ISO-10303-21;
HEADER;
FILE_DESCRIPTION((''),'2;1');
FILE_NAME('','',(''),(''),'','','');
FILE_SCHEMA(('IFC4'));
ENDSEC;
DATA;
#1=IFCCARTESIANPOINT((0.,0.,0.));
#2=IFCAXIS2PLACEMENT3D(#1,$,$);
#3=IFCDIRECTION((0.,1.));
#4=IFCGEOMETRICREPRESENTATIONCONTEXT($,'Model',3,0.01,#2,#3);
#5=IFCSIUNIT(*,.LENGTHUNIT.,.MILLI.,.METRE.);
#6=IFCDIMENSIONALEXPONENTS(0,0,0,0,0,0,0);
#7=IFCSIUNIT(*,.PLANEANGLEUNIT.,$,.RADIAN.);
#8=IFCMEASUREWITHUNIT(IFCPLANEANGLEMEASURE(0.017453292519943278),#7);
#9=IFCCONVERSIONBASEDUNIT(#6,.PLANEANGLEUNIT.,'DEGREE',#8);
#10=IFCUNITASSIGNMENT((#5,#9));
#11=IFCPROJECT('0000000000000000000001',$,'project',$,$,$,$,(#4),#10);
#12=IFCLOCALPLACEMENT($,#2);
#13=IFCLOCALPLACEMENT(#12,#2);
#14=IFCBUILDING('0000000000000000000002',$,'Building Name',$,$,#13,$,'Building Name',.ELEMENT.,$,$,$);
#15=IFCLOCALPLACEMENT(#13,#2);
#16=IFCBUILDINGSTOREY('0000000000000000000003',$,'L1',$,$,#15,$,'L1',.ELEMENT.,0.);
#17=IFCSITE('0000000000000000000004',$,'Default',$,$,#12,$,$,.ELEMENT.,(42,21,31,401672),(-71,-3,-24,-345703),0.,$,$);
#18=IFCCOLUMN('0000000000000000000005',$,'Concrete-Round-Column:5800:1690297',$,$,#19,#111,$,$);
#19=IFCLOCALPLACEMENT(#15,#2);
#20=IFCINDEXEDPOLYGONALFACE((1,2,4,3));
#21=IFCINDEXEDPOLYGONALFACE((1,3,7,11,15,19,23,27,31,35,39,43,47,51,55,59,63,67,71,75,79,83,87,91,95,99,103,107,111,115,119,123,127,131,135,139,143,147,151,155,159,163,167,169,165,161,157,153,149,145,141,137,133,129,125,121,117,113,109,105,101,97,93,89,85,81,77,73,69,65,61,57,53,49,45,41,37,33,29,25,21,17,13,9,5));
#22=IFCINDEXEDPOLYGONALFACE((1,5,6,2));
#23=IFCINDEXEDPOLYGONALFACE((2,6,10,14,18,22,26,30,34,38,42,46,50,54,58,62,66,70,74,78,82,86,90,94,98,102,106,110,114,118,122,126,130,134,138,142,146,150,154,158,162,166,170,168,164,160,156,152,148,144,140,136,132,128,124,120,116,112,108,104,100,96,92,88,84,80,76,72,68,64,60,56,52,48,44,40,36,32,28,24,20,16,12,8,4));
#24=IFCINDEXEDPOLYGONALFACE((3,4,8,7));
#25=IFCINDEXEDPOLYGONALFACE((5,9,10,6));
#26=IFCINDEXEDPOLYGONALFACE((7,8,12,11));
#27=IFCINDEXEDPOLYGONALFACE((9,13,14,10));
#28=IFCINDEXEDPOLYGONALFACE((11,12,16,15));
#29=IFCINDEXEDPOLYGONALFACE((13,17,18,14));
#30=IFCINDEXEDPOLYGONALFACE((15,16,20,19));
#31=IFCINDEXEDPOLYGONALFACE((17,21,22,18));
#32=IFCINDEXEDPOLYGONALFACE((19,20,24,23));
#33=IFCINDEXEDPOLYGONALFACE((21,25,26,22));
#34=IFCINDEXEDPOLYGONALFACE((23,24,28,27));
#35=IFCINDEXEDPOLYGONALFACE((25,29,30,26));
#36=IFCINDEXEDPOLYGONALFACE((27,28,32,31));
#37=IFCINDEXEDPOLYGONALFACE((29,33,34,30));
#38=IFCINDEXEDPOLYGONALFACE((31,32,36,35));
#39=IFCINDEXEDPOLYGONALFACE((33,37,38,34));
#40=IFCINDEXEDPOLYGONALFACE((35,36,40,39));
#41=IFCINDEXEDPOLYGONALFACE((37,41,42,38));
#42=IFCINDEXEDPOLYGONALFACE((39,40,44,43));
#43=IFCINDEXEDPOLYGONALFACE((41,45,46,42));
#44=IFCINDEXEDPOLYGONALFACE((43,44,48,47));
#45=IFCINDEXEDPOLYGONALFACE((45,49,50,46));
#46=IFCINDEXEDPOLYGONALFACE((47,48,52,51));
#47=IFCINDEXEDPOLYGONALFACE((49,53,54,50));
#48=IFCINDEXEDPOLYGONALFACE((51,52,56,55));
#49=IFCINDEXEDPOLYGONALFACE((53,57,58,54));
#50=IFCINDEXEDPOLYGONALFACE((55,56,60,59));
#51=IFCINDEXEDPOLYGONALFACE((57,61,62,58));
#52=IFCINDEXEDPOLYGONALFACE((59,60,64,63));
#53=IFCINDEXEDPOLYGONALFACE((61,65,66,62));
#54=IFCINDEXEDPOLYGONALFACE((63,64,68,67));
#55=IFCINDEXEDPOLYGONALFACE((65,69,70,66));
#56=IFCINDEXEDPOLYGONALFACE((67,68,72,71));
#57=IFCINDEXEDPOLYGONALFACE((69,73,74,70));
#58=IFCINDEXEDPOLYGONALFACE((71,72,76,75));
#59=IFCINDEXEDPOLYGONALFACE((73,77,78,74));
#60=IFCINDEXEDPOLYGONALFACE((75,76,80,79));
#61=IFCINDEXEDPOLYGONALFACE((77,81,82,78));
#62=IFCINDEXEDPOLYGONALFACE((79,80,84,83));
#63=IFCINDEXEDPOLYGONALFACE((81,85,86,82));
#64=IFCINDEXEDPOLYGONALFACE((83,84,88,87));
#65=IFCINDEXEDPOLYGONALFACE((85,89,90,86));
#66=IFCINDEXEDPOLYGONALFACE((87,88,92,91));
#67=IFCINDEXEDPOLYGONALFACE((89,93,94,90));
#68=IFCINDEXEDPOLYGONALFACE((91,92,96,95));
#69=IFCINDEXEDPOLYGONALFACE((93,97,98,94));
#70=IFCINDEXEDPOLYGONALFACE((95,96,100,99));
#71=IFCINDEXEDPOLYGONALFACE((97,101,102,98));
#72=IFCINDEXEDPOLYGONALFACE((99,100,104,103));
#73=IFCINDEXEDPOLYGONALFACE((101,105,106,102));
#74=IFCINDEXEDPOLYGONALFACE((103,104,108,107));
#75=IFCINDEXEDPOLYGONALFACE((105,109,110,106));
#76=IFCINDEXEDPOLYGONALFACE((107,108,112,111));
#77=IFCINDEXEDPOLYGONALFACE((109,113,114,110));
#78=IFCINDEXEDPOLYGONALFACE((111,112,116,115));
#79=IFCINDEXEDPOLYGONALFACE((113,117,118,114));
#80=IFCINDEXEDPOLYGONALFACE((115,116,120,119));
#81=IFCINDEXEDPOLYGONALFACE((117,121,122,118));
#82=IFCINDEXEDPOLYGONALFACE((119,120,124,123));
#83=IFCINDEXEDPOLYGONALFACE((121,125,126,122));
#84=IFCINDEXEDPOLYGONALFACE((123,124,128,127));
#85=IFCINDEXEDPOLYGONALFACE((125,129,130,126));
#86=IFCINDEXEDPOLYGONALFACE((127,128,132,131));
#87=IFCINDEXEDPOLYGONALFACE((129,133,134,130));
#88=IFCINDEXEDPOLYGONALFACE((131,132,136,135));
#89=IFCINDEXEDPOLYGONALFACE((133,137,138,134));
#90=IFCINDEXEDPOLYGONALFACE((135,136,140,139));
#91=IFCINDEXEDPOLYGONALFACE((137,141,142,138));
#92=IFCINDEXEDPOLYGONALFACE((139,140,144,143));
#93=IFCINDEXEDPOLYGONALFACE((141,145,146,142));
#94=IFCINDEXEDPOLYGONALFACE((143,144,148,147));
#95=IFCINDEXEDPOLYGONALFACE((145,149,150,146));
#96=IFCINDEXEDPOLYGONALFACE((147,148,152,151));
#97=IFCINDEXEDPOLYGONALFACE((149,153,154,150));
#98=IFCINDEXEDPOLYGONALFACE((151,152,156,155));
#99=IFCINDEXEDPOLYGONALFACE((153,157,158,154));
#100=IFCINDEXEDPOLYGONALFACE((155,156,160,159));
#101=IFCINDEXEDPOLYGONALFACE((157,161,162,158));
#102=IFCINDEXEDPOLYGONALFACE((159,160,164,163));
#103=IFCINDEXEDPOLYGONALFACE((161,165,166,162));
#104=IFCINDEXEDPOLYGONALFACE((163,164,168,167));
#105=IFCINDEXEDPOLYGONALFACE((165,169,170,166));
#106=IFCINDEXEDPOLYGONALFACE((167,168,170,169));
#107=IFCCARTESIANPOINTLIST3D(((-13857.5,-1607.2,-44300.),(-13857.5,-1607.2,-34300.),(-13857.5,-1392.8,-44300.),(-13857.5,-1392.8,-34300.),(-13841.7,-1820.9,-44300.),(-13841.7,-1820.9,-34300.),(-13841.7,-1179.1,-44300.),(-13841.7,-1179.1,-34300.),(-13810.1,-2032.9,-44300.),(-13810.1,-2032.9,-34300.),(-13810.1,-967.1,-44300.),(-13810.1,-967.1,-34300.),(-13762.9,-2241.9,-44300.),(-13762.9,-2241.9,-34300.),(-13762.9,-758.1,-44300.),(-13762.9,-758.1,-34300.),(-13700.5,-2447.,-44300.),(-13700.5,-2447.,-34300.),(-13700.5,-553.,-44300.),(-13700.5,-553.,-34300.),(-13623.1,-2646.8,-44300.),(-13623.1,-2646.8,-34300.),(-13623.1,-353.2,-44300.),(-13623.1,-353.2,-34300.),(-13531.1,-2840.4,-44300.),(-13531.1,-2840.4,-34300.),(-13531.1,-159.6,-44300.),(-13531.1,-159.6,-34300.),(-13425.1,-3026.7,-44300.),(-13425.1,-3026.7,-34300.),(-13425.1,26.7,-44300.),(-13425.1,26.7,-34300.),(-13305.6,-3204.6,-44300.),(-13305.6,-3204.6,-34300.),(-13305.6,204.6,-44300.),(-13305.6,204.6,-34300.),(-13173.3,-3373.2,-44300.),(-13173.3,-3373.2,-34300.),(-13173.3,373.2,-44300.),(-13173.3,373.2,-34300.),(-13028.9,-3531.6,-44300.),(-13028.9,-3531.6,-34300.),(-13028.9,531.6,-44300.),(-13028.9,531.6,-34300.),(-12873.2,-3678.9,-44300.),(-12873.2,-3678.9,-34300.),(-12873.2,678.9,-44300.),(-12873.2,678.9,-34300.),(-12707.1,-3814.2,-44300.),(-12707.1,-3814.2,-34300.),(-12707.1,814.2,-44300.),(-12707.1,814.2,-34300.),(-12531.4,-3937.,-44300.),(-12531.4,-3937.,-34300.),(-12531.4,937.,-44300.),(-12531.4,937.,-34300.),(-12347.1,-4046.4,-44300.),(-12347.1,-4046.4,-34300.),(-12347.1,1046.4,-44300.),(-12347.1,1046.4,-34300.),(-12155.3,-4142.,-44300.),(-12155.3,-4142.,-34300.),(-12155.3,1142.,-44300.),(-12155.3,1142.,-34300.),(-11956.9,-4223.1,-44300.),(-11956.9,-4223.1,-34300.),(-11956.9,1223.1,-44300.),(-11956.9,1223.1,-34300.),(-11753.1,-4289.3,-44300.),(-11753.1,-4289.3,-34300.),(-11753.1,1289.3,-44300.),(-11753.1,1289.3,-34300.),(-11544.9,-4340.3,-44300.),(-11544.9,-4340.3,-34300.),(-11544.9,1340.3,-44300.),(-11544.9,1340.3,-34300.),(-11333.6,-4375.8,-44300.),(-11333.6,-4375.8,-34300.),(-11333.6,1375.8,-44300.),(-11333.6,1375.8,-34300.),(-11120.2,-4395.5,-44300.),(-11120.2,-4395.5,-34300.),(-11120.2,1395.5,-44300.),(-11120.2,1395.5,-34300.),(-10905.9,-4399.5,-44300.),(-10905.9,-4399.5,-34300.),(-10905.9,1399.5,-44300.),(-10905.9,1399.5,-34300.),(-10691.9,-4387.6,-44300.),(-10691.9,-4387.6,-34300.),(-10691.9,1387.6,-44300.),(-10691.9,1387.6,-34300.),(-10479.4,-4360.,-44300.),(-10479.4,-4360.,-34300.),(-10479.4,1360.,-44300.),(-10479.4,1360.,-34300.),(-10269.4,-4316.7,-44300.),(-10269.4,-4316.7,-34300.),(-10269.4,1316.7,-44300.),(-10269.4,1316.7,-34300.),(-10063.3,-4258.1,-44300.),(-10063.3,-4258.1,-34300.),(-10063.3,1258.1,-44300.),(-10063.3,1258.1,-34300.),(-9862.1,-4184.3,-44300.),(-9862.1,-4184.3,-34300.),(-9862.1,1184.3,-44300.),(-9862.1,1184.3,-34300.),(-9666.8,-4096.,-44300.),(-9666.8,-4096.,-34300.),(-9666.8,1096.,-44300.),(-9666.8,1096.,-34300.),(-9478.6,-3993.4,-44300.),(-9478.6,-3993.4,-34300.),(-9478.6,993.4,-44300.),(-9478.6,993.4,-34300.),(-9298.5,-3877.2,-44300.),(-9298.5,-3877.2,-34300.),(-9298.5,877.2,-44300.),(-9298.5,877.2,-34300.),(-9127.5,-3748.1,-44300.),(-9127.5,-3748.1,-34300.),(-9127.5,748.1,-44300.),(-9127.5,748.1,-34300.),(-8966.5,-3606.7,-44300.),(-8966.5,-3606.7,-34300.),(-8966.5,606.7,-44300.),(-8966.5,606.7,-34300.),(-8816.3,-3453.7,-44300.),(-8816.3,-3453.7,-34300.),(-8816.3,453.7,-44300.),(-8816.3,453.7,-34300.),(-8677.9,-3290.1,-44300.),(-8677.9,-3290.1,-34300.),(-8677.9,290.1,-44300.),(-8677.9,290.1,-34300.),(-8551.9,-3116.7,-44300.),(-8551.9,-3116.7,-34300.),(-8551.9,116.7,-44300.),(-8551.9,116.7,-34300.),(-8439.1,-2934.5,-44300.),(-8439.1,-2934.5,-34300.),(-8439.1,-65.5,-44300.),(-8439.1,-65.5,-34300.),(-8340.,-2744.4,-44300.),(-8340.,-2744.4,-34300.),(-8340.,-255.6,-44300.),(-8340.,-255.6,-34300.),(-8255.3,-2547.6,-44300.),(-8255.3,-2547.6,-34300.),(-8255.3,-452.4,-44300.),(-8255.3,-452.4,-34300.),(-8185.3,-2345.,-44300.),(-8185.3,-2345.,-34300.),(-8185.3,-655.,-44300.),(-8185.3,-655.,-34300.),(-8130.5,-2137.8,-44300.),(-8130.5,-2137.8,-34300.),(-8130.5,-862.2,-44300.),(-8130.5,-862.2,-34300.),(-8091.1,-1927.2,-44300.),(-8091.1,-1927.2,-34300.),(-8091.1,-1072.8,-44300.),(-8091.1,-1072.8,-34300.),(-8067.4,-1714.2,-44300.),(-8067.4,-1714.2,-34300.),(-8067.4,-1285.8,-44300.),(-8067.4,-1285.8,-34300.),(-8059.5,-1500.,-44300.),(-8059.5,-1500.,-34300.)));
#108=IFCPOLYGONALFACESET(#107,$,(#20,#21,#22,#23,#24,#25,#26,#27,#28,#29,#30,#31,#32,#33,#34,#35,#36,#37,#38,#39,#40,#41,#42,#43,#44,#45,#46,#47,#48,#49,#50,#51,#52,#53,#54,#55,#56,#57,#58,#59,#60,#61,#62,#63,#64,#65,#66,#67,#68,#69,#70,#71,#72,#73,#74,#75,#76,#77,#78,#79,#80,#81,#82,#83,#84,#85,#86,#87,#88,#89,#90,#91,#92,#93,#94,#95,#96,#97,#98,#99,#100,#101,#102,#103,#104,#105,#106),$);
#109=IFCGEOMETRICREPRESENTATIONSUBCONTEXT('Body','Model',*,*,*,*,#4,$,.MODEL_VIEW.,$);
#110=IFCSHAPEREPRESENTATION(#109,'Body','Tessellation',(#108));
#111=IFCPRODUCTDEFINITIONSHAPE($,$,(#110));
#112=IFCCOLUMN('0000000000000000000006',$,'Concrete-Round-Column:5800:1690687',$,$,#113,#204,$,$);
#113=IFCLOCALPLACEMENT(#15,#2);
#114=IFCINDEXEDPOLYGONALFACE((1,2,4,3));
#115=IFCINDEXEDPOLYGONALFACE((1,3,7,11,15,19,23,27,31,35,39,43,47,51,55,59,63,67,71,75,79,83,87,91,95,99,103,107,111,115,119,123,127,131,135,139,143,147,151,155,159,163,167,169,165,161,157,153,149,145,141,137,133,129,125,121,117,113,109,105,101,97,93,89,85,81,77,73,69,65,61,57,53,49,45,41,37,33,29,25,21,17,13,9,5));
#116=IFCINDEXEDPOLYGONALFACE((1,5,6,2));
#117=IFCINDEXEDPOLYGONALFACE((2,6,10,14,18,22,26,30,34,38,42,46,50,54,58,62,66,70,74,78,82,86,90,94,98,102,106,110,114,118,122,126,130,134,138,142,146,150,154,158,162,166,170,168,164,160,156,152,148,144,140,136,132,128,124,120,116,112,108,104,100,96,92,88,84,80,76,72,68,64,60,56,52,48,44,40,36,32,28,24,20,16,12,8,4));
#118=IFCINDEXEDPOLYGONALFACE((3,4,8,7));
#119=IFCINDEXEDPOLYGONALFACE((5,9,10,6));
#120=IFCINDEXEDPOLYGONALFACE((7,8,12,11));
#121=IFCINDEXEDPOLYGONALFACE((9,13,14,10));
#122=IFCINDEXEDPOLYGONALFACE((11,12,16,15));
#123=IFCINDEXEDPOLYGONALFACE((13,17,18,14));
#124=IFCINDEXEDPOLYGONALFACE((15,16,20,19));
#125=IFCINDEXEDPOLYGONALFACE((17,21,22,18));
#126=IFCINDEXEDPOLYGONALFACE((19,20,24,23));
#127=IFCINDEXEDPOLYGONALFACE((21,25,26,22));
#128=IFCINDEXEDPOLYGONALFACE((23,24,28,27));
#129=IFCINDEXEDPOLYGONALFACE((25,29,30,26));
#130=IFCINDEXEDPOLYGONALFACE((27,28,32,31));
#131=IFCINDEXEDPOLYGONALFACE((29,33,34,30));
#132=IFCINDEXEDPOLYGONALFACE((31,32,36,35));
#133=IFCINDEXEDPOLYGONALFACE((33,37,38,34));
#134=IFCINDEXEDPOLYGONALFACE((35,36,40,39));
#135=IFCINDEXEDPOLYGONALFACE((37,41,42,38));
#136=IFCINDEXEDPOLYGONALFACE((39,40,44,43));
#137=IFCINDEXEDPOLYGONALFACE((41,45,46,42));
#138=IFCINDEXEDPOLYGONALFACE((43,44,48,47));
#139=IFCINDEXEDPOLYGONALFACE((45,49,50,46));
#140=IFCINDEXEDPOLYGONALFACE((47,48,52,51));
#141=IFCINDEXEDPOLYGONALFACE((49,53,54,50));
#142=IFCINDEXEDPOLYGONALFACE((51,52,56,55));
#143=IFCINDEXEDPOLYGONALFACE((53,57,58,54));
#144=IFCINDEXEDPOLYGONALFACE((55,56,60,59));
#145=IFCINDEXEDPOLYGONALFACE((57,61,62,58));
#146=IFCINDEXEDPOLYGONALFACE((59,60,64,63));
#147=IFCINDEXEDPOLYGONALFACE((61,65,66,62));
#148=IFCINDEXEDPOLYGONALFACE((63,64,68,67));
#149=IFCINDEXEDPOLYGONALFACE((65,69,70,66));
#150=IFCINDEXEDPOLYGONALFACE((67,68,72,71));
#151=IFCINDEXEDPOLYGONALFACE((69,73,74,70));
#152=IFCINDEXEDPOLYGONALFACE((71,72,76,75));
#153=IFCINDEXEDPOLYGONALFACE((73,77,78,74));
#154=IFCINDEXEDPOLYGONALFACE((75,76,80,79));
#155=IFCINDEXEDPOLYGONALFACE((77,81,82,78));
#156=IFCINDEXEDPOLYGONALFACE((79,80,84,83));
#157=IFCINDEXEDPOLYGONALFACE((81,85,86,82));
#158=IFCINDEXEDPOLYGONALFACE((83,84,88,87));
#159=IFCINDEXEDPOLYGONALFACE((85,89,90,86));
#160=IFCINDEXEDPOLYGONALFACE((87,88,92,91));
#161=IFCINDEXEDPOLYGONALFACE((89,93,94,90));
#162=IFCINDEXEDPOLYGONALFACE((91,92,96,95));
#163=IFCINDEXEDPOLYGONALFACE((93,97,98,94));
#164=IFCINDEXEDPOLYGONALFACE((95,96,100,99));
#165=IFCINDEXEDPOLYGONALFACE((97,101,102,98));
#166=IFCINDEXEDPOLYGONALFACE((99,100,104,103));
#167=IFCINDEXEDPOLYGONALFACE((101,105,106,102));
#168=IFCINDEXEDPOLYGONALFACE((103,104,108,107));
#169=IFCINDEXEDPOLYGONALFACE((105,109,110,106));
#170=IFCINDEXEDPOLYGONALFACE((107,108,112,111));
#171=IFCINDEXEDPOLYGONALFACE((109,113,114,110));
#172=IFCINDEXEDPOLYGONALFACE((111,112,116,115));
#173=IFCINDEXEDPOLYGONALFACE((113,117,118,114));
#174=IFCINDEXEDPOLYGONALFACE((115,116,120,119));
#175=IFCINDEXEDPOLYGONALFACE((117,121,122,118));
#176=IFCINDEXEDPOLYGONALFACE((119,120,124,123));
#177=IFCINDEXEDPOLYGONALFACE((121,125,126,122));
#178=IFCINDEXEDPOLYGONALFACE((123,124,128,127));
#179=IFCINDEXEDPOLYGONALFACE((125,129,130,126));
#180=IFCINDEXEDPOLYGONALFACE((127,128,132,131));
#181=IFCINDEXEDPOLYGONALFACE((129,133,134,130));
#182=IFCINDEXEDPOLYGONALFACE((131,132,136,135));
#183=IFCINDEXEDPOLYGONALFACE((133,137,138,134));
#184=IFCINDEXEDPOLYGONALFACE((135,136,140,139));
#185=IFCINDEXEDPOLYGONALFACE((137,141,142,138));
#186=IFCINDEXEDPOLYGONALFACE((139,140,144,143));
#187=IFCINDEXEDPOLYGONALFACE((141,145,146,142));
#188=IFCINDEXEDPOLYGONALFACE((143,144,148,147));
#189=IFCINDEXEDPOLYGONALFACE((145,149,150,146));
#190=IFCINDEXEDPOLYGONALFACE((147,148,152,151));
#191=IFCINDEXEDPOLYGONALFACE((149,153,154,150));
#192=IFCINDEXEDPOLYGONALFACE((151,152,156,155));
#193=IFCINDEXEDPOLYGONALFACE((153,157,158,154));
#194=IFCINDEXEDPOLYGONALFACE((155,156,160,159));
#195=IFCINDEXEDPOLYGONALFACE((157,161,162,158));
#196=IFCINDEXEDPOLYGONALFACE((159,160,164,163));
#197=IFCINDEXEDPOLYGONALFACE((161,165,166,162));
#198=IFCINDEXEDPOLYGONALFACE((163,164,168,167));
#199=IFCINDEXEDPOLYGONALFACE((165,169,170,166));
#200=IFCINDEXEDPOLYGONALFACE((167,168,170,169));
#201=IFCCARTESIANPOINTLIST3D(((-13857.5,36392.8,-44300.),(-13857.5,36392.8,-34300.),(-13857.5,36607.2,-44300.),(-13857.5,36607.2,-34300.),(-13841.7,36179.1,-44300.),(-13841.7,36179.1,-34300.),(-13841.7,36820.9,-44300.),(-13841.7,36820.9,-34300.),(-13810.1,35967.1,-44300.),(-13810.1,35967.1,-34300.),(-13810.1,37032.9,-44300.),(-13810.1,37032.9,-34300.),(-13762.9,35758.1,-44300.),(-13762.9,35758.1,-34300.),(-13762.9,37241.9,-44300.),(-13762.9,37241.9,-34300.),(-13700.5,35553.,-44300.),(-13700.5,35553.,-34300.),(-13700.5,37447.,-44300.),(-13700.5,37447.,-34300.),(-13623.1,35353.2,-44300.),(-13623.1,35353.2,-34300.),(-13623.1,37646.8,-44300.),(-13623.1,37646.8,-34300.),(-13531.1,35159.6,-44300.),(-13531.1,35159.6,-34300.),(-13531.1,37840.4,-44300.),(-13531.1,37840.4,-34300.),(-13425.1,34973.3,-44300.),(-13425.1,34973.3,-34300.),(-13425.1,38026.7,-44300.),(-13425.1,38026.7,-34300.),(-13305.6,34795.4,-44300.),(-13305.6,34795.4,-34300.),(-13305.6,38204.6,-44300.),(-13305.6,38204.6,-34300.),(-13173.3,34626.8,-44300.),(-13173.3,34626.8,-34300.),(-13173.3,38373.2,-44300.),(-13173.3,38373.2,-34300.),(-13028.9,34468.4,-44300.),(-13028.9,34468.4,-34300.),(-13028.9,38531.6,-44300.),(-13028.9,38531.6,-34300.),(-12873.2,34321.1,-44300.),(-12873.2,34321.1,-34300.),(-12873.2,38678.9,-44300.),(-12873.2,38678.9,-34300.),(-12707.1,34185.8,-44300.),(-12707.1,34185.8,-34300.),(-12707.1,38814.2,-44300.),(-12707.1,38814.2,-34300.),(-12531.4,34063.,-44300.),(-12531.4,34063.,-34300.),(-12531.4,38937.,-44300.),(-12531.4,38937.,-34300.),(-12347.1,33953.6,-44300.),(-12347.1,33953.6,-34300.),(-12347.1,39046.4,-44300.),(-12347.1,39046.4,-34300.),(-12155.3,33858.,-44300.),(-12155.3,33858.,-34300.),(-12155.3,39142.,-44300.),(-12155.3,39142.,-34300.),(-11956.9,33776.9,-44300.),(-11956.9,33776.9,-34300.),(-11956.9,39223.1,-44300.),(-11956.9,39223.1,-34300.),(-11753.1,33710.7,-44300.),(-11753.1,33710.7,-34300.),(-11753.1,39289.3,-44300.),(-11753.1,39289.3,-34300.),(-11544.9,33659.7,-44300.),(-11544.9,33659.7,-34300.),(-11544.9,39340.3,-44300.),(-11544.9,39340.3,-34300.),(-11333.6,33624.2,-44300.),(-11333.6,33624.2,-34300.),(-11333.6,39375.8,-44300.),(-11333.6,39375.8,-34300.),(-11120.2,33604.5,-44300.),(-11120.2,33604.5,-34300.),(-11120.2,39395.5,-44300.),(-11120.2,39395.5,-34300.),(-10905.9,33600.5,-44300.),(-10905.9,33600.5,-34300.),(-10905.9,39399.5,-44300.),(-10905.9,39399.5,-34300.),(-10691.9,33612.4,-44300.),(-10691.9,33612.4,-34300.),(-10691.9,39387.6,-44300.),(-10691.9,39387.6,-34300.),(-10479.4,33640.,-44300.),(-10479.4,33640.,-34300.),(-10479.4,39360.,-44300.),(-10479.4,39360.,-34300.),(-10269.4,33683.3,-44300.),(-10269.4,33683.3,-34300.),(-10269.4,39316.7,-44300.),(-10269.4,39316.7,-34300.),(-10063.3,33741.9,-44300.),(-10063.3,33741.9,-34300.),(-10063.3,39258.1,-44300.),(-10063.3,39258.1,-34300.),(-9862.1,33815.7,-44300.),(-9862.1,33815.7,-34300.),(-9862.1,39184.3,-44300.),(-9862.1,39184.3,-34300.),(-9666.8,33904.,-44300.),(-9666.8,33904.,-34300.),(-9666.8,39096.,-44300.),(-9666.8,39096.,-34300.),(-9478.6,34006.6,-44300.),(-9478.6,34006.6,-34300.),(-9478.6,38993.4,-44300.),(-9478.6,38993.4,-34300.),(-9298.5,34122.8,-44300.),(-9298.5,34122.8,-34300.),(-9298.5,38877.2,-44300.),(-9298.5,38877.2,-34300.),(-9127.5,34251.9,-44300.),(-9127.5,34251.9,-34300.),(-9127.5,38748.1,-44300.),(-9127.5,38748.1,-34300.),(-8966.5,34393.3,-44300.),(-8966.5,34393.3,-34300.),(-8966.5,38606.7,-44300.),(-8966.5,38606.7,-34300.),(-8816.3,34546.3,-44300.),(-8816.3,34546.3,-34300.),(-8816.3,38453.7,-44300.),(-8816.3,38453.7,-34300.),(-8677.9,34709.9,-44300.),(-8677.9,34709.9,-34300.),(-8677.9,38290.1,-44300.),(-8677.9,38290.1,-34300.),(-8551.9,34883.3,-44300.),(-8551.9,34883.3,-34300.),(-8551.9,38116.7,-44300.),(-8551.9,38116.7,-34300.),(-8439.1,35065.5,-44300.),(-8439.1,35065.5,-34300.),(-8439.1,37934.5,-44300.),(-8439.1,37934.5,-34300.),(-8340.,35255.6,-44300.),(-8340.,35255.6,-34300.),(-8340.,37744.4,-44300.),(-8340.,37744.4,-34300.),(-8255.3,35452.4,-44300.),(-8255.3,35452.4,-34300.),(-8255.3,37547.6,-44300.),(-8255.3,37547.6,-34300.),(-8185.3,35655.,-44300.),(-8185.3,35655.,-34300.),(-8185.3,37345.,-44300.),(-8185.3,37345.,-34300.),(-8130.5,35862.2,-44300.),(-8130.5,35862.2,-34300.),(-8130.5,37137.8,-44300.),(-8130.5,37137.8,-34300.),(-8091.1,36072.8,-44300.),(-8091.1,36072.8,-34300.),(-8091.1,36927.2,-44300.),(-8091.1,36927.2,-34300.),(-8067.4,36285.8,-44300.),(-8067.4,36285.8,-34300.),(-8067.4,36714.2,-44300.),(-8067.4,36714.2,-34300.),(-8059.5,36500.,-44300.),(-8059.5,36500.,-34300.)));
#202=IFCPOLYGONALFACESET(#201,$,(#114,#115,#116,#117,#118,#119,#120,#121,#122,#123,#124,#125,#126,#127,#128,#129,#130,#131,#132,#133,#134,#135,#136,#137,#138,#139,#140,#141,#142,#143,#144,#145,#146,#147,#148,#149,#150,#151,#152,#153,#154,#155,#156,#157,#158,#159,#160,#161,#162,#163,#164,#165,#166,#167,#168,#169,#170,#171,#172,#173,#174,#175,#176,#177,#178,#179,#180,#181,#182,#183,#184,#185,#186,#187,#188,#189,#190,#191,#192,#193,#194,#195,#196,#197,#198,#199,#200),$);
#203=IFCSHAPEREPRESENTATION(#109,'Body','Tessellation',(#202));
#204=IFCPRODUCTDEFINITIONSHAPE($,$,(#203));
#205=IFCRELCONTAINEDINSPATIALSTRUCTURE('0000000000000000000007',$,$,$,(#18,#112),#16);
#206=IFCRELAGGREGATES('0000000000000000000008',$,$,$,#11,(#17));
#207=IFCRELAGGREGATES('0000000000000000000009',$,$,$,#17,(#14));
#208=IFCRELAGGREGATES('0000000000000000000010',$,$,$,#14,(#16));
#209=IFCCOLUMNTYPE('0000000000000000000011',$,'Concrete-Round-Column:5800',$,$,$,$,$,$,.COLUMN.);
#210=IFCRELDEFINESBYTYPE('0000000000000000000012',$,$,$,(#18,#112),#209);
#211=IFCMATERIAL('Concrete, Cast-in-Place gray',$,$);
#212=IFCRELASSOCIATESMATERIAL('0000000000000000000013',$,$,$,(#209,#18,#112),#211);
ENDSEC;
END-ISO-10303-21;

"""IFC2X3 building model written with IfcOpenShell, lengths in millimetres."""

from ifc_helpers import new_model, entity, si_unit, converted_unit, direction, frame, frame_2d, origin, place, context, subcontext, project, spatial, circle, extrude, source, transform, mapped, material, type_object, type_shapes, element, save


model = new_model("IFC2X3")

# Units and contexts
model_context = context("Model", 3, precision=0.01, world=origin(), true_north=direction((0.0, 1.0)))
body_context = subcontext(model_context, "Body", "Model", "MODEL_VIEW")
ifc_project = project(units=[si_unit("LENGTHUNIT", "METRE", prefix="MILLI"), converted_unit("PLANEANGLEUNIT", "DEGREE", entity("IfcPlaneAngleMeasure", 0.017453292519943278), si_unit("PLANEANGLEUNIT", "RADIAN"), dimensions=[0, 0, 0, 0, 0, 0, 0])], contexts=[model_context])

# Site, building, storey
site_placement = place(None, origin())
site = spatial("IfcSite", under=ifc_project, at=site_placement, Name="Default", CompositionType="ELEMENT", RefLatitude=(42, 21, 31, 401672), RefLongitude=(-71, -3, -24, -345703), RefElevation=0.0)
building_placement = place(site_placement, origin())
building = spatial("IfcBuilding", under=site, at=building_placement, Name="Building Name", LongName="Building Name", CompositionType="ELEMENT")
storey_placement = place(building_placement, origin())
storey = spatial("IfcBuildingStorey", under=building, at=storey_placement, Name="L1", LongName="L1", CompositionType="ELEMENT", Elevation=0.0)

# Columns
ifc_material_1 = material(Name="Concrete, Cast-in-Place gray")
column_type_1 = type_object("IfcColumnType", Name="Concrete-Round-Column:5800", PredefinedType="COLUMN", material=ifc_material_1)
shared_shape_1 = source(origin(), body_context, "Body", "SweptSolid", [
    extrude(circle(Radius=2900.0, at=frame_2d((0.0, 0.0), x_axis=(1.0, 0.0))), frame((0.0, 0.0, -44300.0)), (0.0, 0.0, 1.0), 10000.0),
])
type_shapes(column_type_1, [shared_shape_1])
for number, where, name in (
    (1, (-10959.5, -1500.0, 0.0), "Concrete-Round-Column:5800:1690297"),
    (2, (-10959.5, 36500.0, 0.0), "Concrete-Round-Column:5800:1690687"),
):
    element("IfcColumn", number, at=place(storey_placement, frame(where)), inside=storey, type_object=column_type_1, material=ifc_material_1, Name=name, context=body_context, shape_type="MappedRepresentation", body=[
        mapped(shared_shape_1, transform((0.0, 0.0, 0.0), scale=1.0)),
    ])

save(model, "model.ifc")
